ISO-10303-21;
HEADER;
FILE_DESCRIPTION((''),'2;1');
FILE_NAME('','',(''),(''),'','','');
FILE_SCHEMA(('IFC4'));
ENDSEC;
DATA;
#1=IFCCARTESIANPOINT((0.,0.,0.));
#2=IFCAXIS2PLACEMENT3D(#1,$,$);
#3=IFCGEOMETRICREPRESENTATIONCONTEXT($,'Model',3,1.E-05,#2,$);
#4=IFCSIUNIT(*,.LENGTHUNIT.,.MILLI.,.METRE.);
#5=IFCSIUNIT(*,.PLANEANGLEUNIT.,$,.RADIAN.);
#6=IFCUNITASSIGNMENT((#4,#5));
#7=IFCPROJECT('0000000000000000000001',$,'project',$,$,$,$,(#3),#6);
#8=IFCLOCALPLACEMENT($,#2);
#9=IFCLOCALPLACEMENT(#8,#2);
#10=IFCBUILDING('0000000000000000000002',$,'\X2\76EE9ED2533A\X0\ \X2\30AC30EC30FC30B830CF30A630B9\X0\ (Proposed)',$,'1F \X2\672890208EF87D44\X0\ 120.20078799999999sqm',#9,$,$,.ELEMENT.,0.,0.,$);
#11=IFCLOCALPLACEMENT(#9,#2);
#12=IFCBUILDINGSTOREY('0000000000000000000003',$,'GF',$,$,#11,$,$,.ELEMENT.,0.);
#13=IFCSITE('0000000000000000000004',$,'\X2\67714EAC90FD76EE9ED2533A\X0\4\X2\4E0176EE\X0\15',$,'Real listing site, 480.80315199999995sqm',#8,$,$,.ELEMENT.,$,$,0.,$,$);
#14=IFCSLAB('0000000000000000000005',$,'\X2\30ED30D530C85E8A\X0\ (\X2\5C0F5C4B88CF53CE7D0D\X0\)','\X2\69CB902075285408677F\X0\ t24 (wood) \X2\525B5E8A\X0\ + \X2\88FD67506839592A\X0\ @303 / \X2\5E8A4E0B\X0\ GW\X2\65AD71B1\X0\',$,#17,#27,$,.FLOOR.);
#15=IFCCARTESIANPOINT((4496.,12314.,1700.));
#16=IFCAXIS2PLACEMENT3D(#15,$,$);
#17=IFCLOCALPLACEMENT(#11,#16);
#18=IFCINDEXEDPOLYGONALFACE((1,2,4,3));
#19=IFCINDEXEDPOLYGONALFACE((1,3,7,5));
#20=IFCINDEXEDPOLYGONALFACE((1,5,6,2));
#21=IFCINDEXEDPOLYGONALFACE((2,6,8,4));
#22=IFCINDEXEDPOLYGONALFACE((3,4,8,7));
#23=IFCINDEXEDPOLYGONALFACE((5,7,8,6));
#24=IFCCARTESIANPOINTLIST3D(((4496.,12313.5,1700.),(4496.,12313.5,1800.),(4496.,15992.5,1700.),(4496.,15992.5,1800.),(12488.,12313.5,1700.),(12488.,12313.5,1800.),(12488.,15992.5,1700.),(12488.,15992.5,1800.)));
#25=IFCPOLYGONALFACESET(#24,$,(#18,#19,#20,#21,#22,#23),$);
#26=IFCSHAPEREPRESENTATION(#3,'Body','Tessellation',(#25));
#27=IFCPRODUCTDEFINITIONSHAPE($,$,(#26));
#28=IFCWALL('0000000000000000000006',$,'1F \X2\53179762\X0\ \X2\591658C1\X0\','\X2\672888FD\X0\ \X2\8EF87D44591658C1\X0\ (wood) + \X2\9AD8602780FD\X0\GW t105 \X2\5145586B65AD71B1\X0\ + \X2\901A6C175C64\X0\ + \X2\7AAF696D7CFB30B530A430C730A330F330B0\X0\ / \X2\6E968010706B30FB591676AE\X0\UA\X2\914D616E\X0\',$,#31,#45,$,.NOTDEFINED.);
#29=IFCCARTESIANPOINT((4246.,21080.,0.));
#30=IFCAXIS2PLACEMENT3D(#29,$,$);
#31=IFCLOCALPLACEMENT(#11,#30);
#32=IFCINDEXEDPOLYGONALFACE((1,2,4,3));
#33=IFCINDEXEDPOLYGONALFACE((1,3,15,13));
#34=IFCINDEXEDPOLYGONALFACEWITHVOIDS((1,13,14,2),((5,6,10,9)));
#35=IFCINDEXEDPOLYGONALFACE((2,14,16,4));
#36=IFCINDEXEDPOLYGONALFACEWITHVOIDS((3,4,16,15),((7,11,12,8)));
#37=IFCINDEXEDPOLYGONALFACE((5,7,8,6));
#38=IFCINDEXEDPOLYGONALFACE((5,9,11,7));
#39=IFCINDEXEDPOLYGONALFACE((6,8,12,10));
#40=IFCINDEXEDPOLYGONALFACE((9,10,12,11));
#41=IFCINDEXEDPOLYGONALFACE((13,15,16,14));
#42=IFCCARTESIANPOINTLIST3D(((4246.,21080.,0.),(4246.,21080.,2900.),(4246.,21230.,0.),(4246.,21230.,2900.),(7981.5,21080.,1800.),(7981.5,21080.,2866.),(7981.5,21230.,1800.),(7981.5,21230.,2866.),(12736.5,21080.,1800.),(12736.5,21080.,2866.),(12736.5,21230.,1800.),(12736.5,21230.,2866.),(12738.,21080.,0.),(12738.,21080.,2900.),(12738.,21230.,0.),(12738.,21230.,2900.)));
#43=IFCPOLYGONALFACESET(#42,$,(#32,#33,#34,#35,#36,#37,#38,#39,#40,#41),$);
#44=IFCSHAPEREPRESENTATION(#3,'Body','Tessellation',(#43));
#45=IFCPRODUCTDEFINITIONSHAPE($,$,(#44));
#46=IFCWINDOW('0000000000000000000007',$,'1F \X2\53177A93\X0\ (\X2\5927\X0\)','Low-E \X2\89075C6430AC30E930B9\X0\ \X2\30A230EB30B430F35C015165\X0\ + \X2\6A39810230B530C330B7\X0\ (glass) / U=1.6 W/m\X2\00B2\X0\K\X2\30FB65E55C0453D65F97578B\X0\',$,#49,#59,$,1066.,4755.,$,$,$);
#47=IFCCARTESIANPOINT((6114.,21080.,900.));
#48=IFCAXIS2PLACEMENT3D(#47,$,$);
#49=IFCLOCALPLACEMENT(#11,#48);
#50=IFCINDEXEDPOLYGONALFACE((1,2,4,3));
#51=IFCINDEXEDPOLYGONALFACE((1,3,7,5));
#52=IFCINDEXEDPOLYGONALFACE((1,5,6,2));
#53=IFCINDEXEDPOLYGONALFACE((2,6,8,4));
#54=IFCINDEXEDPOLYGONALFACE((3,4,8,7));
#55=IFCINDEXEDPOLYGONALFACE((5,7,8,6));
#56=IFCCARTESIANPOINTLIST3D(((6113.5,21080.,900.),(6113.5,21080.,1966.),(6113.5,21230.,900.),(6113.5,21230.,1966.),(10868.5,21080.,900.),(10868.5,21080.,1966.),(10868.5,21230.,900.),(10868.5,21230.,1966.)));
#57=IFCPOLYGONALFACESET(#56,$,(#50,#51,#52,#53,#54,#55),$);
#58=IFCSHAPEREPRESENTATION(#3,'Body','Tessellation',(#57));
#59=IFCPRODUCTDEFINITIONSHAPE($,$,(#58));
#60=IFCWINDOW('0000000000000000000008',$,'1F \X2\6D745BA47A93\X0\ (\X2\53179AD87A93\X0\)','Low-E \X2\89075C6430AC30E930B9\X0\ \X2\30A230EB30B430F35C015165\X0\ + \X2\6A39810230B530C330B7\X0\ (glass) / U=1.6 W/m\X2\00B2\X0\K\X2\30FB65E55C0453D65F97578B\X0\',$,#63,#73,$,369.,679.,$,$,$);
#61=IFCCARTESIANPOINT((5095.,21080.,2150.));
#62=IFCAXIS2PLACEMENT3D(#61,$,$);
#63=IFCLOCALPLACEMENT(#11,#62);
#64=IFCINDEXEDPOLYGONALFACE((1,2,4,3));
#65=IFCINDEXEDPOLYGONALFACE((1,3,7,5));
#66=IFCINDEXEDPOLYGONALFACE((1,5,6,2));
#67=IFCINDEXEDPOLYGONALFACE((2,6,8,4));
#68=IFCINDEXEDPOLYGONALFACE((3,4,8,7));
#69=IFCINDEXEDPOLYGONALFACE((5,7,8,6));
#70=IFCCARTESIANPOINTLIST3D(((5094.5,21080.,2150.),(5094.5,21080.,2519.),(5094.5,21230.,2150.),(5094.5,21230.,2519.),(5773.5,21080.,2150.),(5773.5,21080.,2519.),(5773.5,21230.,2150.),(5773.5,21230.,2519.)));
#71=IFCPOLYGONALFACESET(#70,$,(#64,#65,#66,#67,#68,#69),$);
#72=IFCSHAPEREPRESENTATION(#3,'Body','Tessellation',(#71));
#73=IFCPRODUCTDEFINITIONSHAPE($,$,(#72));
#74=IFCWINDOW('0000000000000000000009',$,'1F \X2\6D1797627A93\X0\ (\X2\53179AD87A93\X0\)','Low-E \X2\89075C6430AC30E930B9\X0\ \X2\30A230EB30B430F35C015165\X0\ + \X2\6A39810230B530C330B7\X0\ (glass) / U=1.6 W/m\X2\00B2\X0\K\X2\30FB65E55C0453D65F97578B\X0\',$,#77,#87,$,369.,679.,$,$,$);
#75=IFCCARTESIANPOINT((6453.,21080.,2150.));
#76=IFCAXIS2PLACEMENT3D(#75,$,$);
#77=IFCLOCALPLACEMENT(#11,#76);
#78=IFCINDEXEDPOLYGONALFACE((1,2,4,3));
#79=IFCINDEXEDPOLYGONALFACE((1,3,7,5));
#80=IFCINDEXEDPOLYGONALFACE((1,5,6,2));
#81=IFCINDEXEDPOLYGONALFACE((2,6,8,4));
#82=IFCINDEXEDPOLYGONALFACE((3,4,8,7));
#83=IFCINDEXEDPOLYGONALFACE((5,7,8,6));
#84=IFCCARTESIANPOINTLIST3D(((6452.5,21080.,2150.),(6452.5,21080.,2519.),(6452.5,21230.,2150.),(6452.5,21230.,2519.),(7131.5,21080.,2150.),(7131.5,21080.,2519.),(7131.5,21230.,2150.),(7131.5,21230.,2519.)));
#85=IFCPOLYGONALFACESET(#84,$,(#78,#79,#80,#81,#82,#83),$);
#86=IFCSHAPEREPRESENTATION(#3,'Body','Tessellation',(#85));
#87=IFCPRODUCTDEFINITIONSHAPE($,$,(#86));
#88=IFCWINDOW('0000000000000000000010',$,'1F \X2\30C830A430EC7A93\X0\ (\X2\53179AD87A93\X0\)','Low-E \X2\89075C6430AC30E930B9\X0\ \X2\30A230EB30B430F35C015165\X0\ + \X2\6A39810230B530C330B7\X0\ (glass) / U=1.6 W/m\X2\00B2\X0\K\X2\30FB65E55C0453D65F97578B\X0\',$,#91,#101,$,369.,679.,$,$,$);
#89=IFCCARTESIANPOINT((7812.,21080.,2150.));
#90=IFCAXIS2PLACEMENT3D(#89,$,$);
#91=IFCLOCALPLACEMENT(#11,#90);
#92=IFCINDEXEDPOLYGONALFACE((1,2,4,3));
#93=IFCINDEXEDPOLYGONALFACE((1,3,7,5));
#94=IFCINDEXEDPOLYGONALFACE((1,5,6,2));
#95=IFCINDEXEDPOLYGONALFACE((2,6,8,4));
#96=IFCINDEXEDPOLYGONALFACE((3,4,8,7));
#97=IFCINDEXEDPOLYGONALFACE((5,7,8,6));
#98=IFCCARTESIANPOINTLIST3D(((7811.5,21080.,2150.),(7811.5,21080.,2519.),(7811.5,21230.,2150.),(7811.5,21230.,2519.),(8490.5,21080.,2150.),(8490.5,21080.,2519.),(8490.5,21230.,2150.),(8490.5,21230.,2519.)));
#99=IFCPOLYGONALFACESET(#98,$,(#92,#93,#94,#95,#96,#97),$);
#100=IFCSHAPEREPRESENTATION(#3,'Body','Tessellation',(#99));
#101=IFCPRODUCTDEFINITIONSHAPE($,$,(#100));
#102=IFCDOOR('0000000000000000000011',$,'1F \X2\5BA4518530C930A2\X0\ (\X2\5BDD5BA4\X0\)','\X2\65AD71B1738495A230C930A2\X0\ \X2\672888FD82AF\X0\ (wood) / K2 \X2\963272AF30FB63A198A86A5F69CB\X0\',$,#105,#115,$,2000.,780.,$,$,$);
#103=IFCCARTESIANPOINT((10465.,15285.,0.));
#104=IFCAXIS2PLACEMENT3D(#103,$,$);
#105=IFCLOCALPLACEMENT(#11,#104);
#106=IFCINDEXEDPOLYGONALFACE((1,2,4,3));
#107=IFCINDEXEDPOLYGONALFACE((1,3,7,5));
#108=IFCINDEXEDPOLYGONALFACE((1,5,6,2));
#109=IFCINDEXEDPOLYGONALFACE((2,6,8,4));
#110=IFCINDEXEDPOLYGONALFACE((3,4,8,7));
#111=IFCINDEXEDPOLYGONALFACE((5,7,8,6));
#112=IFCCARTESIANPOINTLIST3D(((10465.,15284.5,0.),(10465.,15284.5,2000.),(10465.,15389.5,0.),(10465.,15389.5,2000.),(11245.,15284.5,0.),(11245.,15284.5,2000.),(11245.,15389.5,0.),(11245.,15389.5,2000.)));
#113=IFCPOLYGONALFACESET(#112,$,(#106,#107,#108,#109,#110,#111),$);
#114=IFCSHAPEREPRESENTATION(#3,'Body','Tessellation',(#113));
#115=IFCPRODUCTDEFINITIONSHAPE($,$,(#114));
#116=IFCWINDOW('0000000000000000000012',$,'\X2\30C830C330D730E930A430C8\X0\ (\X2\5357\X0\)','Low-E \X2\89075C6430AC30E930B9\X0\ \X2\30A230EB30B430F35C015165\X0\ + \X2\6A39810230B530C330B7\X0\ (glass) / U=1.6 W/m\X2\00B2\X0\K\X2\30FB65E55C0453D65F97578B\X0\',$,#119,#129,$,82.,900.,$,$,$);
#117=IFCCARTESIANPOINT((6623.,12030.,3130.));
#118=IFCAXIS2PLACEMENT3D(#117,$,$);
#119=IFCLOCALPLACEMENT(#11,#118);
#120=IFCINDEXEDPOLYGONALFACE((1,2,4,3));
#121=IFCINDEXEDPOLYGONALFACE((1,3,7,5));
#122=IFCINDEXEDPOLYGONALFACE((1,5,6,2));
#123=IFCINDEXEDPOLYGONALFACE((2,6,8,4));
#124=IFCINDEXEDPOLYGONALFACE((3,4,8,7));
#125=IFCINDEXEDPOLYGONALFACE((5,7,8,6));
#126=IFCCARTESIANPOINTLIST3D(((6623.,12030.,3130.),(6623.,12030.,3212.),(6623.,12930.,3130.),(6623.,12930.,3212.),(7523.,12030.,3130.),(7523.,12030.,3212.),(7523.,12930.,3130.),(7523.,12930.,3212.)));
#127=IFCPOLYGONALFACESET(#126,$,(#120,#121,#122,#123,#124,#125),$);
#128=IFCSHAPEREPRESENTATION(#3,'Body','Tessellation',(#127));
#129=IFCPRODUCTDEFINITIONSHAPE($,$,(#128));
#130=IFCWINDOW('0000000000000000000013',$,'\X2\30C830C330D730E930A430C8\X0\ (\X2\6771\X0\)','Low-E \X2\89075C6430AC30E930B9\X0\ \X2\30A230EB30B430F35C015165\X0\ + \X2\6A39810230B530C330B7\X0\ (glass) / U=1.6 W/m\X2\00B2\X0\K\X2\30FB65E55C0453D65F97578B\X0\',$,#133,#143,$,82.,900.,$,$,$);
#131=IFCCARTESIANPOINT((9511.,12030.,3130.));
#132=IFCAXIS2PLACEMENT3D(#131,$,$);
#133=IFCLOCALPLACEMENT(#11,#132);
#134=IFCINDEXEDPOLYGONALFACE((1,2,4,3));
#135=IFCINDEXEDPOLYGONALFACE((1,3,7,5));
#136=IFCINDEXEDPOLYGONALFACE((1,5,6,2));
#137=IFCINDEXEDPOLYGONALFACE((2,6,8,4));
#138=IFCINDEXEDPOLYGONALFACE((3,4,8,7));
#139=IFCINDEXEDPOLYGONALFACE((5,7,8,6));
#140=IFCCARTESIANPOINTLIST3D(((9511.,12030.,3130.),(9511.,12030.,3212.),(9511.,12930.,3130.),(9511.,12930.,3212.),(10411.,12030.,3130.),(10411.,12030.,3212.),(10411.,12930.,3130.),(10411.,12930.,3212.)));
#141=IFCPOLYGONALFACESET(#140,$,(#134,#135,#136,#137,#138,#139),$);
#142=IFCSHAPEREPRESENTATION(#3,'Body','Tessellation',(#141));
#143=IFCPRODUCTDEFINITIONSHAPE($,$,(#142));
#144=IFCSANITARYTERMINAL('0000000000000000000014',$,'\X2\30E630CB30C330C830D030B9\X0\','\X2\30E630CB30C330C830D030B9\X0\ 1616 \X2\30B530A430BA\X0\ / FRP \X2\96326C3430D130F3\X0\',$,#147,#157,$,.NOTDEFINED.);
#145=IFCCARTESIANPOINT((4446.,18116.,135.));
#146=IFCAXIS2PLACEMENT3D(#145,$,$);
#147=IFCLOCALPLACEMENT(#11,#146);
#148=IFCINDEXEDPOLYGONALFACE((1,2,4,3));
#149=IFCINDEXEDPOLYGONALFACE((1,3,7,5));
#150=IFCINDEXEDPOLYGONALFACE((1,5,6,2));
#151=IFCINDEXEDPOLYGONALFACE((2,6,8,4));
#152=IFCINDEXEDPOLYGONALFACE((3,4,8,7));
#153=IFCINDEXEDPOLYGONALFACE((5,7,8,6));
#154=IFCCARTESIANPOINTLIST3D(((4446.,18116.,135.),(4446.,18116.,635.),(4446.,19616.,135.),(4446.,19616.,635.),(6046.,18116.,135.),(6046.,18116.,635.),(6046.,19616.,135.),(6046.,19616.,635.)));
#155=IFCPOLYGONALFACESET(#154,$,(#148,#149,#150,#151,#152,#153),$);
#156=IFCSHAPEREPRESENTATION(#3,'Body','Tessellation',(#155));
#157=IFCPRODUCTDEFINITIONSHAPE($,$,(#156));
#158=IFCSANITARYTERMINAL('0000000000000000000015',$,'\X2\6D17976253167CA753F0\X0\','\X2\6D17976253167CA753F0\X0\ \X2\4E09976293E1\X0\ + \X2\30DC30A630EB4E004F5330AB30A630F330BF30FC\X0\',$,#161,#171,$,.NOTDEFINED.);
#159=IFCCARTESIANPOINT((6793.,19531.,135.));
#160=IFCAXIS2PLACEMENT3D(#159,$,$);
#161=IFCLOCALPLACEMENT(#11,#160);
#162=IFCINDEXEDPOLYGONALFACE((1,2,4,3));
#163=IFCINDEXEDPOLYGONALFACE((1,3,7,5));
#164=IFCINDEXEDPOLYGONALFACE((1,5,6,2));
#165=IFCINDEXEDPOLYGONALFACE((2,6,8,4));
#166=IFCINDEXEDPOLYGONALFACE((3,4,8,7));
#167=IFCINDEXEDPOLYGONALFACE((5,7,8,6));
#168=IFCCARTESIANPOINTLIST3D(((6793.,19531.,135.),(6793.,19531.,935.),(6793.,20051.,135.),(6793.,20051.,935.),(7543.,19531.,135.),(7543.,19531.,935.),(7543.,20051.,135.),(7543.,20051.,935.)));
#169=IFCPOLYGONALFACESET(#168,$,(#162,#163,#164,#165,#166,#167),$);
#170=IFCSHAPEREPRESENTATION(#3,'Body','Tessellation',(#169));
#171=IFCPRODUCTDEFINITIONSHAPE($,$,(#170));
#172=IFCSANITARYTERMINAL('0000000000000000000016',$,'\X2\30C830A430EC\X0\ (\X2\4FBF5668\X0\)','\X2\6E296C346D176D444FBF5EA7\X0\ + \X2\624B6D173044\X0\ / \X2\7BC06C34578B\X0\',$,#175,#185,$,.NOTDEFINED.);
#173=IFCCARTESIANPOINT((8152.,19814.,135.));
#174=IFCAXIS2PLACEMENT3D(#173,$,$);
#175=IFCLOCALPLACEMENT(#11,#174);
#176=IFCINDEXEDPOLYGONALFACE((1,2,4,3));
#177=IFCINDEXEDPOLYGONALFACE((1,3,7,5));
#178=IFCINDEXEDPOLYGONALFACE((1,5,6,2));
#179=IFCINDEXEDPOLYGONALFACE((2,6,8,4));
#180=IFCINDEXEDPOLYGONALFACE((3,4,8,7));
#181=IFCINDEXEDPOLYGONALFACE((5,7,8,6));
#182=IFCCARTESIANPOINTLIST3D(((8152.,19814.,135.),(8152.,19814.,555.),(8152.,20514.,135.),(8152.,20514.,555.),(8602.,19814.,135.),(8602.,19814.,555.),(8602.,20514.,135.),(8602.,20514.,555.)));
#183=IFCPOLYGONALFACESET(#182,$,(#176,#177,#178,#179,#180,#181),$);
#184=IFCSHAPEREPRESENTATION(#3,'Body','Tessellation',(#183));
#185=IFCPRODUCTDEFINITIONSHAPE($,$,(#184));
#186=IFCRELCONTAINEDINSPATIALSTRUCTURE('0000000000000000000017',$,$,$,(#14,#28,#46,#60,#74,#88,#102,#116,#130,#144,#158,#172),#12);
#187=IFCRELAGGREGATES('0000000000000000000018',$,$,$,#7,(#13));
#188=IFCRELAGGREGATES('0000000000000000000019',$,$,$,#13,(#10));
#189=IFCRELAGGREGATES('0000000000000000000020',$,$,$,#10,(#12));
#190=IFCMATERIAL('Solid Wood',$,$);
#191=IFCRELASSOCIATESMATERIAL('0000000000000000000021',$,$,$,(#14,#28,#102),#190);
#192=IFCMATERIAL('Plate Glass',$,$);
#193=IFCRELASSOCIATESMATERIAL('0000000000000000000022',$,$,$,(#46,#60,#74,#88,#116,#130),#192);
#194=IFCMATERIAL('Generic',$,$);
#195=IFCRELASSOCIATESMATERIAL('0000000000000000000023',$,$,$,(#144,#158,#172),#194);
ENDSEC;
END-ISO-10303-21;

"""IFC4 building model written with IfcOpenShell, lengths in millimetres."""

from ifc_helpers import new_model, si_unit, frame, frame_2d, origin, place, context, project, spatial, rectangle, extrude, material, element, fill, save


model = new_model("IFC4")

# Units and contexts
model_context = context("Model", 3, precision=1e-05, world=origin())
ifc_project = project(units=[si_unit("LENGTHUNIT", "METRE", prefix="MILLI"), si_unit("PLANEANGLEUNIT", "RADIAN")], contexts=[model_context])

# Site, building, storey
site_placement = place(None, origin())
site = spatial("IfcSite", under=ifc_project, at=site_placement, Name="東京都目黒区4丁目15", ObjectType="Real listing site, 480.80315199999995sqm", CompositionType="ELEMENT", RefElevation=0.0)
building_placement = place(site_placement, origin())
building = spatial("IfcBuilding", under=site, at=building_placement, Name="目黒区 ガレージハウス (Proposed)", ObjectType="1F 木造軸組 120.20078799999999sqm", CompositionType="ELEMENT", ElevationOfRefHeight=0.0, ElevationOfTerrain=0.0)
storey_placement = place(building_placement, origin())
storey = spatial("IfcBuildingStorey", under=building, at=storey_placement, Name="GF", CompositionType="ELEMENT", Elevation=0.0)

# Slab
ifc_material_1 = material(Name="Solid Wood")
slab_placement = place(storey_placement, frame((4496.0, 12314.0, 1700.0)))
element("IfcSlab", 1, at=slab_placement, inside=storey, material=ifc_material_1, Name="ロフト床 (小屋裏収納)", Description="構造用合板 t24 (wood) 剛床 + 製材根太 @303 / 床下 GW断熱", PredefinedType="FLOOR", context=model_context, shape_type="SweptSolid", body=[
    extrude(rectangle(XDim=7992.0, YDim=3679.0, at=frame_2d((3996.0, 1839.0))), frame((4496.0, 12314.0, 1700.0)), (0.0, 0.0, 1.0), 100.0),
])

# Wall, openings, windows
wall_1_placement = place(storey_placement, frame((4246.0, 21080.0, 0.0)))
wall_1 = element("IfcWall", 2, at=wall_1_placement, inside=storey, material=ifc_material_1, Name="1F 北面 外壁", Description="木製 軸組外壁 (wood) + 高性能GW t105 充填断熱 + 通気層 + 窯業系サイディング / 準耐火・外皮UA配慮", PredefinedType="NOTDEFINED", context=model_context, shape_type="SweptSolid", body=[
    extrude(rectangle(XDim=8492.0, YDim=150.0, at=frame_2d((4246.0, 75.0))), frame((4246.0, 21080.0, 0.0)), (0.0, 0.0, 1.0), 2900.0),
])
opening_1_placement = place(storey_placement, frame((6114.0, 21080.0, 900.0)))
opening_1 = element("IfcOpeningElement", 3, at=opening_1_placement, cuts=wall_1, PredefinedType="NOTDEFINED", context=model_context, shape_type="SweptSolid", body=[
    extrude(rectangle(XDim=4755.0, YDim=150.0, at=frame_2d((2377.0, 75.0))), frame((6114.0, 21080.0, 900.0)), (0.0, 0.0, 1.0), 1066.0),
])
opening_2_placement = place(storey_placement, frame((5095.0, 21080.0, 2150.0)))
opening_2 = element("IfcOpeningElement", 4, at=opening_2_placement, cuts=wall_1, PredefinedType="NOTDEFINED", context=model_context, shape_type="SweptSolid", body=[
    extrude(rectangle(XDim=679.0, YDim=150.0, at=frame_2d((339.0, 75.0))), frame((5095.0, 21080.0, 2150.0)), (0.0, 0.0, 1.0), 369.0),
])
opening_3_placement = place(storey_placement, frame((6453.0, 21080.0, 2150.0)))
opening_3 = element("IfcOpeningElement", 5, at=opening_3_placement, cuts=wall_1, PredefinedType="NOTDEFINED", context=model_context, shape_type="SweptSolid", body=[
    extrude(rectangle(XDim=679.0, YDim=150.0, at=frame_2d((339.0, 75.0))), frame((6453.0, 21080.0, 2150.0)), (0.0, 0.0, 1.0), 369.0),
])
opening_4_placement = place(storey_placement, frame((7812.0, 21080.0, 2150.0)))
opening_4 = element("IfcOpeningElement", 6, at=opening_4_placement, cuts=wall_1, PredefinedType="NOTDEFINED", context=model_context, shape_type="SweptSolid", body=[
    extrude(rectangle(XDim=679.0, YDim=150.0, at=frame_2d((339.0, 75.0))), frame((7812.0, 21080.0, 2150.0)), (0.0, 0.0, 1.0), 369.0),
])
ifc_material_2 = material(Name="Plate Glass")
window_1_placement = place(storey_placement, frame((6114.0, 21080.0, 900.0)))
window_1 = element("IfcWindow", 7, at=window_1_placement, inside=storey, material=ifc_material_2, Name="1F 北窓 (大)", Description="Low-E 複層ガラス アルゴン封入 + 樹脂サッシ (glass) / U=1.6 W/m²K・日射取得型", OverallHeight=1066.0, OverallWidth=4755.0, context=model_context, shape_type="SweptSolid", body=[
    extrude(rectangle(XDim=4755.0, YDim=150.0, at=frame_2d((2377.0, 75.0))), frame((6114.0, 21080.0, 900.0)), (0.0, 0.0, 1.0), 1066.0),
])
fill(opening_1, window_1)
window_2_placement = place(storey_placement, frame((5095.0, 21080.0, 2150.0)))
window_2 = element("IfcWindow", 8, at=window_2_placement, inside=storey, material=ifc_material_2, Name="1F 浴室窓 (北高窓)", Description="Low-E 複層ガラス アルゴン封入 + 樹脂サッシ (glass) / U=1.6 W/m²K・日射取得型", OverallHeight=369.0, OverallWidth=679.0, context=model_context, shape_type="SweptSolid", body=[
    extrude(rectangle(XDim=679.0, YDim=150.0, at=frame_2d((339.0, 75.0))), frame((5095.0, 21080.0, 2150.0)), (0.0, 0.0, 1.0), 369.0),
])
fill(opening_2, window_2)
window_3_placement = place(storey_placement, frame((6453.0, 21080.0, 2150.0)))
window_3 = element("IfcWindow", 9, at=window_3_placement, inside=storey, material=ifc_material_2, Name="1F 洗面窓 (北高窓)", Description="Low-E 複層ガラス アルゴン封入 + 樹脂サッシ (glass) / U=1.6 W/m²K・日射取得型", OverallHeight=369.0, OverallWidth=679.0, context=model_context, shape_type="SweptSolid", body=[
    extrude(rectangle(XDim=679.0, YDim=150.0, at=frame_2d((339.0, 75.0))), frame((6453.0, 21080.0, 2150.0)), (0.0, 0.0, 1.0), 369.0),
])
fill(opening_3, window_3)
window_4_placement = place(storey_placement, frame((7812.0, 21080.0, 2150.0)))
window_4 = element("IfcWindow", 10, at=window_4_placement, inside=storey, material=ifc_material_2, Name="1F トイレ窓 (北高窓)", Description="Low-E 複層ガラス アルゴン封入 + 樹脂サッシ (glass) / U=1.6 W/m²K・日射取得型", OverallHeight=369.0, OverallWidth=679.0, context=model_context, shape_type="SweptSolid", body=[
    extrude(rectangle(XDim=679.0, YDim=150.0, at=frame_2d((339.0, 75.0))), frame((7812.0, 21080.0, 2150.0)), (0.0, 0.0, 1.0), 369.0),
])
fill(opening_4, window_4)

# Door
door_1_placement = place(storey_placement, frame((10465.0, 15285.0, 0.0)))
element("IfcDoor", 11, at=door_1_placement, inside=storey, material=ifc_material_1, Name="1F 室内ドア (寝室)", Description="断熱玄関ドア 木製芯 (wood) / K2 防犯・採風機構", OverallHeight=2000.0, OverallWidth=780.0, context=model_context, shape_type="SweptSolid", body=[
    extrude(rectangle(XDim=780.0, YDim=105.0, at=frame_2d((390.0, 52.0))), frame((10465.0, 15285.0, 0.0)), (0.0, 0.0, 1.0), 2000.0),
])

# Windows
window_5_placement = place(storey_placement, frame((6623.0, 12030.0, 3130.0)))
element("IfcWindow", 12, at=window_5_placement, inside=storey, material=ifc_material_2, Name="トップライト (南)", Description="Low-E 複層ガラス アルゴン封入 + 樹脂サッシ (glass) / U=1.6 W/m²K・日射取得型", OverallHeight=82.0, OverallWidth=900.0, context=model_context, shape_type="SweptSolid", body=[
    extrude(rectangle(XDim=900.0, YDim=900.0, at=frame_2d((450.0, 450.0))), frame((6623.0, 12030.0, 3130.0)), (0.0, 0.0, 1.0), 82.0),
])
window_6_placement = place(storey_placement, frame((9511.0, 12030.0, 3130.0)))
element("IfcWindow", 13, at=window_6_placement, inside=storey, material=ifc_material_2, Name="トップライト (東)", Description="Low-E 複層ガラス アルゴン封入 + 樹脂サッシ (glass) / U=1.6 W/m²K・日射取得型", OverallHeight=82.0, OverallWidth=900.0, context=model_context, shape_type="SweptSolid", body=[
    extrude(rectangle(XDim=900.0, YDim=900.0, at=frame_2d((450.0, 450.0))), frame((9511.0, 12030.0, 3130.0)), (0.0, 0.0, 1.0), 82.0),
])

# Sanitary terminals
ifc_material_3 = material(Name="Generic")
sanitary_terminal_1_placement = place(storey_placement, frame((4446.0, 18116.0, 135.0)))
element("IfcSanitaryTerminal", 14, at=sanitary_terminal_1_placement, inside=storey, material=ifc_material_3, Name="ユニットバス", Description="ユニットバス 1616 サイズ / FRP 防水パン", PredefinedType="NOTDEFINED", context=model_context, shape_type="SweptSolid", body=[
    extrude(rectangle(XDim=1600.0, YDim=1500.0, at=frame_2d((800.0, 750.0))), frame((4446.0, 18116.0, 135.0)), (0.0, 0.0, 1.0), 500.0),
])
sanitary_terminal_2_placement = place(storey_placement, frame((6793.0, 19531.0, 135.0)))
element("IfcSanitaryTerminal", 15, at=sanitary_terminal_2_placement, inside=storey, material=ifc_material_3, Name="洗面化粧台", Description="洗面化粧台 三面鏡 + ボウル一体カウンター", PredefinedType="NOTDEFINED", context=model_context, shape_type="SweptSolid", body=[
    extrude(rectangle(XDim=750.0, YDim=520.0, at=frame_2d((375.0, 260.0))), frame((6793.0, 19531.0, 135.0)), (0.0, 0.0, 1.0), 800.0),
])
sanitary_terminal_3_placement = place(storey_placement, frame((8152.0, 19814.0, 135.0)))
element("IfcSanitaryTerminal", 16, at=sanitary_terminal_3_placement, inside=storey, material=ifc_material_3, Name="トイレ (便器)", Description="温水洗浄便座 + 手洗い / 節水型", PredefinedType="NOTDEFINED", context=model_context, shape_type="SweptSolid", body=[
    extrude(rectangle(XDim=450.0, YDim=700.0, at=frame_2d((225.0, 350.0))), frame((8152.0, 19814.0, 135.0)), (0.0, 0.0, 1.0), 420.0),
])

save(model, "model.ifc")
